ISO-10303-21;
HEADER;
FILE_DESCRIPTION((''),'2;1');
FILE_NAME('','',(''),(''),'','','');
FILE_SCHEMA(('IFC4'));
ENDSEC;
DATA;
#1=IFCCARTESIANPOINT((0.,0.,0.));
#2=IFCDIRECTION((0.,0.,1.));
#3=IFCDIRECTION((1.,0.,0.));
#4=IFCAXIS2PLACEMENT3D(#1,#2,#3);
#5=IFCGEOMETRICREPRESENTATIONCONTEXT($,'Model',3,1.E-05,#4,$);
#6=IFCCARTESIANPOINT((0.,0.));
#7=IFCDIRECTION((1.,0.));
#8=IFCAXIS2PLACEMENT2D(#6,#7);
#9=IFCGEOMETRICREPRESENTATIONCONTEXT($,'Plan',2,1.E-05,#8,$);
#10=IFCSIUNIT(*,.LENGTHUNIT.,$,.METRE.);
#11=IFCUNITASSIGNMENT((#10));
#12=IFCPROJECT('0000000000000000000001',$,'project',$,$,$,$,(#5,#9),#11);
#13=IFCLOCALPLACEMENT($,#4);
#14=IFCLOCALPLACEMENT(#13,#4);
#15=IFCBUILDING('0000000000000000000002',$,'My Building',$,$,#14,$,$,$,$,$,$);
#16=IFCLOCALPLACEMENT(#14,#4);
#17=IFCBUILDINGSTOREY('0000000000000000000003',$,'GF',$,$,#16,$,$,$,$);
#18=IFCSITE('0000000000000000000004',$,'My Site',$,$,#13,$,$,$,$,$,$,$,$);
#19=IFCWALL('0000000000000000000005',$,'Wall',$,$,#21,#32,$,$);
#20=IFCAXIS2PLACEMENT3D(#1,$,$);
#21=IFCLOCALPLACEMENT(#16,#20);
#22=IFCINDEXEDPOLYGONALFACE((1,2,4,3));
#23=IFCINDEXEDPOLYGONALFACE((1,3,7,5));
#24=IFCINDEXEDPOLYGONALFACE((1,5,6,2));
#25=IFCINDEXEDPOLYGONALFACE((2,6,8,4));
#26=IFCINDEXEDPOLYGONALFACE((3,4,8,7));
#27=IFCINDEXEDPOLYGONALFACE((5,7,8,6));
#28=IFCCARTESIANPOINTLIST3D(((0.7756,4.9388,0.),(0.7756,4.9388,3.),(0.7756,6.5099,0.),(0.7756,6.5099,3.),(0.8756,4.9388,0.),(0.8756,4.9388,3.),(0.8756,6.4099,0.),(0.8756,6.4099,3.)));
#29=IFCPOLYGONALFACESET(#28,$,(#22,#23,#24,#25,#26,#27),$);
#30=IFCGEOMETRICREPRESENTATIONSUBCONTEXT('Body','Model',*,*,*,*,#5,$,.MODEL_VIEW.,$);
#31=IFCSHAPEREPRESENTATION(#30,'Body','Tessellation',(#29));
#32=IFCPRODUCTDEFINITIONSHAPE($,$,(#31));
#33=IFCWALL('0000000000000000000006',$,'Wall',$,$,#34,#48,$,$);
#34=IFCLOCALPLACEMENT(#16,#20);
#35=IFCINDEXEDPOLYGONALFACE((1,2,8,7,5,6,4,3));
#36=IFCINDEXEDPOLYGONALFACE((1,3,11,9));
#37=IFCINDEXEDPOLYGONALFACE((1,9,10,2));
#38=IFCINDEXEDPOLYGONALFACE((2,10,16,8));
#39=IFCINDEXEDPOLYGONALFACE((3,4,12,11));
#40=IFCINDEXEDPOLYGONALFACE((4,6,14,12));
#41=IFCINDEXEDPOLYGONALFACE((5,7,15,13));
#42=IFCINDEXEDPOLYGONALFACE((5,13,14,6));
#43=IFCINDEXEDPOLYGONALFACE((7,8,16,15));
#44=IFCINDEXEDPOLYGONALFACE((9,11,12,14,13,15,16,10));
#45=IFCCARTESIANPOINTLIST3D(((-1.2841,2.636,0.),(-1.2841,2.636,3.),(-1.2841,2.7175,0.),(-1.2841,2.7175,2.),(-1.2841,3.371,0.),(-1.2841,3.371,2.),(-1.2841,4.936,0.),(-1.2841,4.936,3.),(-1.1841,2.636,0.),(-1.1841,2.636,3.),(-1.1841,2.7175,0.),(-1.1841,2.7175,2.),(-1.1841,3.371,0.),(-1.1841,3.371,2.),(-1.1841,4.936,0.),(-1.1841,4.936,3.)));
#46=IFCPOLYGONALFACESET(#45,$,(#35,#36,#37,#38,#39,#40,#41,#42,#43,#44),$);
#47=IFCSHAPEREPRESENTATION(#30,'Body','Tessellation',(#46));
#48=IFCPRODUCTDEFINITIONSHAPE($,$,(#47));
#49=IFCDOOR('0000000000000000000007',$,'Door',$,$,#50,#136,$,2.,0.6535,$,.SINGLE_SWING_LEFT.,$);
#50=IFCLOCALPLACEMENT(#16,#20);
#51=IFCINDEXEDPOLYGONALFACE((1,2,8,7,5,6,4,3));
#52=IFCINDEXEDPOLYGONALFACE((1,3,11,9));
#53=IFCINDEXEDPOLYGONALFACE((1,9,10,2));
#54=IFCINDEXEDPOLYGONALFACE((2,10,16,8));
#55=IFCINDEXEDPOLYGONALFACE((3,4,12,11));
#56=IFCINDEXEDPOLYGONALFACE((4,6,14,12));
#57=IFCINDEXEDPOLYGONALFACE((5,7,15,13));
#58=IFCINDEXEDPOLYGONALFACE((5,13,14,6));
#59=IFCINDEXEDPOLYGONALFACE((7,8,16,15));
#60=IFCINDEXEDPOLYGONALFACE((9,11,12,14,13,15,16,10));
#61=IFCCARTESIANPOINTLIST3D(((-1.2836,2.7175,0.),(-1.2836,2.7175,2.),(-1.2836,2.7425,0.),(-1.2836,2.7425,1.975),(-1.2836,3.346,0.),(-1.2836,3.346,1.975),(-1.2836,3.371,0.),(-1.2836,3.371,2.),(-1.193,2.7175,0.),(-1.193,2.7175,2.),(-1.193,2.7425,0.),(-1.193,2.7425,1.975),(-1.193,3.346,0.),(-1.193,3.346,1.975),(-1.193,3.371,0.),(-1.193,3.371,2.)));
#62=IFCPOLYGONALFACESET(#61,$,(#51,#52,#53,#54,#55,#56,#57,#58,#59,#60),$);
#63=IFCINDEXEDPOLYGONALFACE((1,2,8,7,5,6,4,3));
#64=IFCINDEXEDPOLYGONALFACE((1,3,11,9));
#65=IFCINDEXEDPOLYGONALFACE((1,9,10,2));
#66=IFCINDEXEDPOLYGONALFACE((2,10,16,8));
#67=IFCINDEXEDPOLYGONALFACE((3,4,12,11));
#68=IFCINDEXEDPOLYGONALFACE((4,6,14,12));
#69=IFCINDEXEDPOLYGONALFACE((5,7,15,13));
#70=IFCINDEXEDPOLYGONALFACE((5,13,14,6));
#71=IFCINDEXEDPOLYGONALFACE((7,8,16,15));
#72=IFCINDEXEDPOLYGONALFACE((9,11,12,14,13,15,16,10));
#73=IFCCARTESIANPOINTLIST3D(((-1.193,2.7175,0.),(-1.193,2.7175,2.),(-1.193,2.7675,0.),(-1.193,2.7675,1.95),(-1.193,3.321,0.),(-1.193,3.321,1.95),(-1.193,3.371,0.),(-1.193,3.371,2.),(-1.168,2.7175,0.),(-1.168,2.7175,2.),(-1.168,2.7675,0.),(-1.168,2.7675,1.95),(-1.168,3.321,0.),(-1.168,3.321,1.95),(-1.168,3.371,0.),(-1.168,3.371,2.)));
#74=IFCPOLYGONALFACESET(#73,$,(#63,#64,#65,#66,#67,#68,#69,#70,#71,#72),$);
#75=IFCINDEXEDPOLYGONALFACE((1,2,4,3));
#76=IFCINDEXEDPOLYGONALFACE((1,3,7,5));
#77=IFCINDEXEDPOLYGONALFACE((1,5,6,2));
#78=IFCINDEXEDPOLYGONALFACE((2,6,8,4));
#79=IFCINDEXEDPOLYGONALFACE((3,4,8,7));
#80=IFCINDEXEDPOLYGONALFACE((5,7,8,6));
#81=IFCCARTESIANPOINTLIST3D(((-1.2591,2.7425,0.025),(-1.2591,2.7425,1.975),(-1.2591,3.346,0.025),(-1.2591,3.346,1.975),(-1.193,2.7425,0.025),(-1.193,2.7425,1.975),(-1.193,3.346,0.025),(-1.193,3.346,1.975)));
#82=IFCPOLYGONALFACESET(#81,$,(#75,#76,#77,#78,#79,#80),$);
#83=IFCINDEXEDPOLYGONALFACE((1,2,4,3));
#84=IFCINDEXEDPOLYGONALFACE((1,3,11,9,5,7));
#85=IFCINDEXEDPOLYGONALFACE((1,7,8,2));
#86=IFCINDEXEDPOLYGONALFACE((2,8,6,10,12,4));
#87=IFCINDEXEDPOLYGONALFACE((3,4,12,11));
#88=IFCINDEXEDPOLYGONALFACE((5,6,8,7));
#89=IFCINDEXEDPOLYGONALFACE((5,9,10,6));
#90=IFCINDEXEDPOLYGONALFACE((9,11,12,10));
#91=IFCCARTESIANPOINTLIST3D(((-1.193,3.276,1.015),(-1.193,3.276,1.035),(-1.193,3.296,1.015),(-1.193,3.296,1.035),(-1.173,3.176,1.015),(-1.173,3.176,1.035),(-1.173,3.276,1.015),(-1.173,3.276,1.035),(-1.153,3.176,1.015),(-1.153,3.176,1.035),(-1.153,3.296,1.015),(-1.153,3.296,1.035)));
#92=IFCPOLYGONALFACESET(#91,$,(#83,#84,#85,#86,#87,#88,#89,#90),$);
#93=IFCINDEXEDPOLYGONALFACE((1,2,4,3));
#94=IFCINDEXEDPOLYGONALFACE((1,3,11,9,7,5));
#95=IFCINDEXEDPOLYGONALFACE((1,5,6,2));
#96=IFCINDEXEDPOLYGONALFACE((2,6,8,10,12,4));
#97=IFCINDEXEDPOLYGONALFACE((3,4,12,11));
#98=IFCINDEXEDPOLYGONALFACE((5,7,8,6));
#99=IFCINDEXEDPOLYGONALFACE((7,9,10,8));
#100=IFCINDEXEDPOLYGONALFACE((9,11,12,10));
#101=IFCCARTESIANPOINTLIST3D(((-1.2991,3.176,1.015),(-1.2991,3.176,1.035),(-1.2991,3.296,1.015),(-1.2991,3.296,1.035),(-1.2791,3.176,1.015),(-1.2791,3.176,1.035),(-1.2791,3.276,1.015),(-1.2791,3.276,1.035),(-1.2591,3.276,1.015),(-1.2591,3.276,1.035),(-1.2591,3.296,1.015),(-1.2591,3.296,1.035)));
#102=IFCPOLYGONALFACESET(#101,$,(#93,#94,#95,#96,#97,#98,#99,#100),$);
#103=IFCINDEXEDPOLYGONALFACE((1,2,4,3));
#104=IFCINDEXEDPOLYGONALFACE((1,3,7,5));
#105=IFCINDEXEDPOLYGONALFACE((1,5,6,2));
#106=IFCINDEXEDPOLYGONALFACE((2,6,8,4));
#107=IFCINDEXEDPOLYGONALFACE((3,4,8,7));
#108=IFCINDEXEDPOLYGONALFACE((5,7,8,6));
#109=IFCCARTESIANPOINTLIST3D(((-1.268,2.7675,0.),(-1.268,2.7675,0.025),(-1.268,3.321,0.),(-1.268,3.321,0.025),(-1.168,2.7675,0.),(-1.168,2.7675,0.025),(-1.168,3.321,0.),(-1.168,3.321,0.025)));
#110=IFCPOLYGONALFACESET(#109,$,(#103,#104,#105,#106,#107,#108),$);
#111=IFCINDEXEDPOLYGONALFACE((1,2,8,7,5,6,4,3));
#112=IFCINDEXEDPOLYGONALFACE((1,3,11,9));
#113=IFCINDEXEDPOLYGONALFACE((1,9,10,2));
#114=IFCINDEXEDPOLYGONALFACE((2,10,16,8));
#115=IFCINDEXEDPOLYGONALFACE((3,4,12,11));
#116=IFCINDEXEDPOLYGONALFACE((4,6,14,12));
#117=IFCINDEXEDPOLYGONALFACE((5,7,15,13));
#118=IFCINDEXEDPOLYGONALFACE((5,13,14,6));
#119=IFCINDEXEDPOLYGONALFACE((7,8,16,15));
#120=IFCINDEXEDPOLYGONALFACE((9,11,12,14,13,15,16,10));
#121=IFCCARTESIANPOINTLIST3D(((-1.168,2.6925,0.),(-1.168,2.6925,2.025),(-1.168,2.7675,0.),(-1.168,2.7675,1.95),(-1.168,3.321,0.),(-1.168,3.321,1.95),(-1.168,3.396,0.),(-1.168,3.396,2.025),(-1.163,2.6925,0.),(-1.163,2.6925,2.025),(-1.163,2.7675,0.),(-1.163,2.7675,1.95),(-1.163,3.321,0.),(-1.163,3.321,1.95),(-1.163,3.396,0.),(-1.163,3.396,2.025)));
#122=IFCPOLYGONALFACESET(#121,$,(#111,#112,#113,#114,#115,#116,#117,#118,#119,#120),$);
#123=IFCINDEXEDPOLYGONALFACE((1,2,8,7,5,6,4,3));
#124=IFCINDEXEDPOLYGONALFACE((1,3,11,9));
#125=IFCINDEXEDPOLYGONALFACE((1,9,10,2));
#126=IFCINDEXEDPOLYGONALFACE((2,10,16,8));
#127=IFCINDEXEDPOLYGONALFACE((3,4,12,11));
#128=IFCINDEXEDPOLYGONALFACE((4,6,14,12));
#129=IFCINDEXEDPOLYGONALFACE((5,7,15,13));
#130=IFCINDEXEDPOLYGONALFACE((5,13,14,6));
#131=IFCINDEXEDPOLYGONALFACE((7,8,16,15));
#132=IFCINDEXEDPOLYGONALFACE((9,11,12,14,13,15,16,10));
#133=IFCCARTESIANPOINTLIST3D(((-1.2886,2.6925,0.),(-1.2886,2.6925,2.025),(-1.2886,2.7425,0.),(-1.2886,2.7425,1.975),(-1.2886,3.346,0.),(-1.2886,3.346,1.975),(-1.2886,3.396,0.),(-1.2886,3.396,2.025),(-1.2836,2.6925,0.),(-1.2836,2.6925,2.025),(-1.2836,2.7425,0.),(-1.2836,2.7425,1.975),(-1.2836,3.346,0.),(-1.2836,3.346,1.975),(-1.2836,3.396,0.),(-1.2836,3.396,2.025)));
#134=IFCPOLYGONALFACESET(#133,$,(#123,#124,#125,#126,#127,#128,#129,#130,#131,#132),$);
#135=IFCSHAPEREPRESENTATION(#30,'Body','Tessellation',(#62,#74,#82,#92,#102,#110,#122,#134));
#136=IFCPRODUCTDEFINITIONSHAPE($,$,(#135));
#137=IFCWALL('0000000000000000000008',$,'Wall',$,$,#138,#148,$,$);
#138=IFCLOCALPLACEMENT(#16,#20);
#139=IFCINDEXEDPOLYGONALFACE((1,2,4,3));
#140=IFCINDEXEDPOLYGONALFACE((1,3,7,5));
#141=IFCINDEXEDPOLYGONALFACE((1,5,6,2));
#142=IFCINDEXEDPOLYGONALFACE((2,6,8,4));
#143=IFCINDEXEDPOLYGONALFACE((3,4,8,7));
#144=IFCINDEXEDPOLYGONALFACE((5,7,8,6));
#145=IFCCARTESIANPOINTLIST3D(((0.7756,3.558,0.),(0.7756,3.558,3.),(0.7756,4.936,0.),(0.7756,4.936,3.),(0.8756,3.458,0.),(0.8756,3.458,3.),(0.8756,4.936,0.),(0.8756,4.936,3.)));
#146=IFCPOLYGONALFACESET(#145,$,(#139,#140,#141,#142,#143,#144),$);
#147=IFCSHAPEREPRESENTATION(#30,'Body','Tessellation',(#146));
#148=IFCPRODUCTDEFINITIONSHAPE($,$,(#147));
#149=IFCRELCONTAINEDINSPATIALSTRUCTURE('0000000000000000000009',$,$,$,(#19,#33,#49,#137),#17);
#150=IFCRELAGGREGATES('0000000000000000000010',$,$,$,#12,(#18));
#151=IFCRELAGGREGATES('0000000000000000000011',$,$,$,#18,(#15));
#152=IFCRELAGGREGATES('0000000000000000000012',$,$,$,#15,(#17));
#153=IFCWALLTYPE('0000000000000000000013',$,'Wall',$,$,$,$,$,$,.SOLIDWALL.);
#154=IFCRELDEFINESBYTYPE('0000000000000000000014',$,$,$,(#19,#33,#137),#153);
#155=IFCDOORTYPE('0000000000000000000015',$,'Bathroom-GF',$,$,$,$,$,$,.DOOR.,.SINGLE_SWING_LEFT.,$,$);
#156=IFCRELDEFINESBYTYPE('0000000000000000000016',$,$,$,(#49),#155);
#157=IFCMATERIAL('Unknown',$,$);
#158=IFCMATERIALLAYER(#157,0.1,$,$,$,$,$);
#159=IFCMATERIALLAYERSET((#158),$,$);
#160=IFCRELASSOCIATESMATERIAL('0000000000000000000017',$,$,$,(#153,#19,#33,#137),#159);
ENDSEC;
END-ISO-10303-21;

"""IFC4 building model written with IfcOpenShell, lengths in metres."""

from ifc_helpers import new_model, entity, si_unit, frame, origin_with_axes, origin_2d_with_axis, place, context, subcontext, project, spatial, line, indexed_curve, outline, extrude, shape, source, transform, mapped, material, layer, layer_set, layer_usage, type_object, type_shapes, element, fill, save


model = new_model("IFC4")

# Units and contexts
model_context = context("Model", 3, precision=1e-05, world=origin_with_axes())
plan_context = context("Plan", 2, precision=1e-05, world=origin_2d_with_axis())
body_context_1 = subcontext(model_context, "Body", "Model", "MODEL_VIEW")
body_context_2 = subcontext(plan_context, "Body", "Plan", "PLAN_VIEW")
ifc_project = project(units=[si_unit("LENGTHUNIT", "METRE")], contexts=[model_context, plan_context])

# Site, building, storey
site_placement = place(None, origin_with_axes())
site = spatial("IfcSite", under=ifc_project, at=site_placement, Name="My Site")
building_placement = place(site_placement, origin_with_axes())
building = spatial("IfcBuilding", under=site, at=building_placement, Name="My Building")
storey_placement = place(building_placement, origin_with_axes())
storey = spatial("IfcBuildingStorey", under=building, at=storey_placement, Name="GF")

# Shared definitions
ifc_material_1 = material(Name="Unknown")

# Shared definitions
ifc_layer_1 = layer(ifc_material_1, 0.1)
ifc_layer_set_1 = layer_set([ifc_layer_1])
wall_type = type_object("IfcWallType", Name="Wall", PredefinedType="SOLIDWALL", material=ifc_layer_set_1)

# Wall
ifc_layer_usage_1 = layer_usage(ifc_layer_set_1, "AXIS2", "POSITIVE", 0.0)
wall_1_placement = place(storey_placement, frame((0.7756, 6.5099, 0.0), z_axis=(0.0, 0.0, 1.0), x_axis=(0.0, -1.0, 0.0)))
element("IfcWall", 1, at=wall_1_placement, inside=storey, type_object=wall_type, material=ifc_layer_usage_1, Name="Wall", context=body_context_1, shape_type="SweptSolid", body=[
    extrude(outline(indexed_curve([(0.0, 0.0), (0.1, 0.1), (1.5711, 0.1), (1.5711, 0.0)], segments=[line(1, 2, 3, 4, 1)])), origin_with_axes(), (0.0, 0.0, 1.0), 3.0),
])

# Wall, opening, door
ifc_layer_usage_2 = layer_usage(ifc_layer_set_1, "AXIS2", "POSITIVE", 0.0)
wall_2_placement = place(storey_placement, frame((-1.1841, 2.636, 0.0), z_axis=(0.0, 0.0, 1.0), x_axis=(0.0, 1.0, 0.0)))
wall_2 = element("IfcWall", 2, at=wall_2_placement, inside=storey, type_object=wall_type, material=ifc_layer_usage_2, Name="Wall", context=body_context_1, shape_type="SweptSolid", body=[
    extrude(outline(indexed_curve([(0.0, 0.0), (0.0, 0.1), (2.3, 0.1), (2.3, 0.0)], segments=[line(1, 2, 3, 4, 1)])), origin_with_axes(), (0.0, 0.0, 1.0), 3.0),
])
shared_shape_1 = source(origin_with_axes(), body_context_1, "Body", "SweptSolid", [
    extrude(outline(indexed_curve([(0.0, 0.0), (0.6535, 0.0), (0.6535, 2.0), (0.0, 2.0)], segments=[line(1, 2, 3, 4, 1)])), frame((0.0, -0.6, 0.0), z_axis=(0.0, -1.0, 0.0), x_axis=(1.0, 0.0, 0.0)), (0.0, 0.0, -1.0), 1.2),
])
opening_1_placement = place(wall_2_placement, frame((0.0815, -0.0161, 0.0), z_axis=(0.0, 0.0, 1.0), x_axis=(1.0, 0.0, 0.0)))
opening_1 = element("IfcOpeningElement", 3, at=opening_1_placement, cuts=wall_2, PredefinedType="OPENING", context=body_context_1, shape_type="MappedRepresentation", body=[
    mapped(shared_shape_1, transform((0.0, 0.0, 0.0), x_axis=(1.0, 0.0, 0.0), y_axis=(0.0, 1.0, 0.0), z_axis=(0.0, 0.0, 1.0), scale=1.0)),
])
door_type_1 = type_object("IfcDoorType", Name="Bathroom-GF", OperationType="SINGLE_SWING_LEFT", PredefinedType="DOOR")
shared_shape_2 = source(origin_with_axes(), body_context_1, "Body", "SweptSolid", [
    extrude(outline(indexed_curve([(0.0, 0.0), (0.0, 2.0), (0.6535, 2.0), (0.6535, 0.0), (0.6285, 0.0), (0.6285, 1.975), (0.025, 1.975), (0.025, 0.0)], segments=[line(1, 2, 3, 4, 5, 6, 7, 8, 1)])), frame((0.0, 0.025, 0.0), z_axis=(0.0, -1.0, 0.0), x_axis=(1.0, 0.0, 0.0)), (0.0, 0.0, -1.0), 0.0906),
    extrude(outline(indexed_curve([(0.0, 0.0), (0.0, 2.0), (0.6535, 2.0), (0.6535, 0.0), (0.6035, 0.0), (0.6035, 1.95), (0.05, 1.95), (0.05, 0.0)], segments=[line(1, 2, 3, 4, 5, 6, 7, 8, 1)])), frame((0.0, 0.0, 0.0), z_axis=(0.0, -1.0, 0.0), x_axis=(1.0, 0.0, 0.0)), (0.0, 0.0, -1.0), 0.025),
    extrude(outline(indexed_curve([(0.0, 0.0), (0.6035, 0.0), (0.6035, 0.0661), (0.0, 0.0661)], segments=[line(1, 2, 3, 4, 1)])), frame((0.025, 0.025, 0.025), z_axis=(0.0, 0.0, 1.0), x_axis=(1.0, 0.0, 0.0)), (0.0, 0.0, 1.0), 1.95),
    extrude(outline(indexed_curve([(0.0, 0.0), (0.0, -0.04), (-0.12, -0.04), (-0.12, -0.02), (-0.02, -0.02), (-0.02, 0.0)], segments=[line(1, 2, 3, 4, 5, 6, 1)])), frame((0.5785, 0.025, 1.015), z_axis=(0.0, 0.0, 1.0), x_axis=(1.0, 0.0, 0.0)), (0.0, 0.0, 1.0), 0.02),
    extrude(outline(indexed_curve([(0.0, 0.0), (0.0, 0.04), (-0.12, 0.04), (-0.12, 0.02), (-0.02, 0.02), (-0.02, 0.0)], segments=[line(1, 2, 3, 4, 5, 6, 1)])), frame((0.5785, 0.0911, 1.015), z_axis=(0.0, 0.0, 1.0), x_axis=(1.0, 0.0, 0.0)), (0.0, 0.0, 1.0), 0.02),
    extrude(outline(indexed_curve([(0.0, 0.0), (0.5535, 0.0), (0.5535, 0.1), (0.0, 0.1)], segments=[line(1, 2, 3, 4, 1)])), frame((0.05, 0.0, 0.0), z_axis=(0.0, 0.0, 1.0), x_axis=(1.0, 0.0, 0.0)), (0.0, 0.0, 1.0), 0.025),
    extrude(outline(indexed_curve([(0.0, 0.0), (0.0, 2.025), (0.7035, 2.025), (0.7035, 0.0), (0.6285, 0.0), (0.6285, 1.95), (0.075, 1.95), (0.075, 0.0)], segments=[line(1, 2, 3, 4, 5, 6, 7, 8, 1)])), frame((-0.025, -0.005, 0.0), z_axis=(0.0, -1.0, 0.0), x_axis=(1.0, 0.0, 0.0)), (0.0, 0.0, -1.0), 0.005),
    extrude(outline(indexed_curve([(0.0, 0.0), (0.0, 2.025), (0.7035, 2.025), (0.7035, 0.0), (0.6535, 0.0), (0.6535, 1.975), (0.05, 1.975), (0.05, 0.0)], segments=[line(1, 2, 3, 4, 5, 6, 7, 8, 1)])), frame((-0.025, 0.1156, 0.0), z_axis=(0.0, -1.0, 0.0), x_axis=(1.0, 0.0, 0.0)), (0.0, 0.0, -1.0), 0.005),
])
shared_shape_3 = source(origin_with_axes(), body_context_2, "Body", "Curve2D", [
    entity("IfcIndexedPolyCurve", entity("IfcCartesianPointList2D", [[0.0, 0.0], [0.0, 0.1156], [0.025, 0.1156], [0.025, 0.025], [0.05, 0.025], [0.05, 0.0]]), [entity("IfcLineIndex", [1, 2, 3, 4, 5, 6, 1])]),
    entity("IfcIndexedPolyCurve", entity("IfcCartesianPointList2D", [[0.6535, 0.0], [0.6535, 0.1156], [0.6285, 0.1156], [0.6285, 0.025], [0.6035, 0.025], [0.6035, 0.0]]), [entity("IfcLineIndex", [1, 2, 3, 4, 5, 6, 1])]),
    entity("IfcTrimmedCurve", entity("IfcEllipse", entity("IfcAxis2Placement2D", entity("IfcCartesianPoint", [0.0911, 0.1156]), entity("IfcDirection", [1.0, 0.0])), 0.5374, 0.6035), [entity("IfcCartesianPoint", [0.6285, 0.1156])], [entity("IfcCartesianPoint", [0.0911, 0.7191])], True, "CARTESIAN"),
    entity("IfcIndexedPolyCurve", entity("IfcCartesianPointList2D", [[0.025, 0.1156], [0.0911, 0.1156], [0.0911, 0.7191], [0.025, 0.7191]]), [entity("IfcLineIndex", [1, 2, 3, 4, 1])]),
])
type_shapes(door_type_1, [shared_shape_2, shared_shape_3])
door_1_placement = place(opening_1_placement, origin_with_axes())
door_1 = element("IfcDoor", 4, at=door_1_placement, inside=storey, type_object=door_type_1, Name="Door", OperationType="SINGLE_SWING_LEFT", OverallHeight=2.0, OverallWidth=0.6535, shapes=[
    shape(body_context_1, "Body", "MappedRepresentation", [mapped(shared_shape_2, transform((0.0, 0.0, 0.0), x_axis=(1.0, 0.0, 0.0), y_axis=(0.0, 1.0, 0.0), z_axis=(0.0, 0.0, 1.0), scale=1.0))]),
    shape(body_context_2, "Body", "MappedRepresentation", [mapped(shared_shape_3, transform((0.0, 0.0, 0.0), x_axis=(1.0, 0.0, 0.0), y_axis=(0.0, 1.0, 0.0), z_axis=(0.0, 0.0, 1.0), scale=1.0))]),
])
fill(opening_1, door_1)

# Wall
ifc_layer_usage_3 = layer_usage(ifc_layer_set_1, "AXIS2", "POSITIVE", 0.0)
wall_3_placement = place(storey_placement, frame((0.7756, 5.036, 0.0), z_axis=(0.0, 0.0, 1.0), x_axis=(0.0, -1.0, 0.0)))
element("IfcWall", 5, at=wall_3_placement, inside=storey, type_object=wall_type, material=ifc_layer_usage_3, Name="Wall", context=body_context_1, shape_type="SweptSolid", body=[
    extrude(outline(indexed_curve([(0.1, 0.0), (0.1, 0.1), (1.5779, 0.1), (1.4779, 0.0)], segments=[line(1, 2, 3, 4, 1)])), origin_with_axes(), (0.0, 0.0, 1.0), 3.0),
])

save(model, "model.ifc")
